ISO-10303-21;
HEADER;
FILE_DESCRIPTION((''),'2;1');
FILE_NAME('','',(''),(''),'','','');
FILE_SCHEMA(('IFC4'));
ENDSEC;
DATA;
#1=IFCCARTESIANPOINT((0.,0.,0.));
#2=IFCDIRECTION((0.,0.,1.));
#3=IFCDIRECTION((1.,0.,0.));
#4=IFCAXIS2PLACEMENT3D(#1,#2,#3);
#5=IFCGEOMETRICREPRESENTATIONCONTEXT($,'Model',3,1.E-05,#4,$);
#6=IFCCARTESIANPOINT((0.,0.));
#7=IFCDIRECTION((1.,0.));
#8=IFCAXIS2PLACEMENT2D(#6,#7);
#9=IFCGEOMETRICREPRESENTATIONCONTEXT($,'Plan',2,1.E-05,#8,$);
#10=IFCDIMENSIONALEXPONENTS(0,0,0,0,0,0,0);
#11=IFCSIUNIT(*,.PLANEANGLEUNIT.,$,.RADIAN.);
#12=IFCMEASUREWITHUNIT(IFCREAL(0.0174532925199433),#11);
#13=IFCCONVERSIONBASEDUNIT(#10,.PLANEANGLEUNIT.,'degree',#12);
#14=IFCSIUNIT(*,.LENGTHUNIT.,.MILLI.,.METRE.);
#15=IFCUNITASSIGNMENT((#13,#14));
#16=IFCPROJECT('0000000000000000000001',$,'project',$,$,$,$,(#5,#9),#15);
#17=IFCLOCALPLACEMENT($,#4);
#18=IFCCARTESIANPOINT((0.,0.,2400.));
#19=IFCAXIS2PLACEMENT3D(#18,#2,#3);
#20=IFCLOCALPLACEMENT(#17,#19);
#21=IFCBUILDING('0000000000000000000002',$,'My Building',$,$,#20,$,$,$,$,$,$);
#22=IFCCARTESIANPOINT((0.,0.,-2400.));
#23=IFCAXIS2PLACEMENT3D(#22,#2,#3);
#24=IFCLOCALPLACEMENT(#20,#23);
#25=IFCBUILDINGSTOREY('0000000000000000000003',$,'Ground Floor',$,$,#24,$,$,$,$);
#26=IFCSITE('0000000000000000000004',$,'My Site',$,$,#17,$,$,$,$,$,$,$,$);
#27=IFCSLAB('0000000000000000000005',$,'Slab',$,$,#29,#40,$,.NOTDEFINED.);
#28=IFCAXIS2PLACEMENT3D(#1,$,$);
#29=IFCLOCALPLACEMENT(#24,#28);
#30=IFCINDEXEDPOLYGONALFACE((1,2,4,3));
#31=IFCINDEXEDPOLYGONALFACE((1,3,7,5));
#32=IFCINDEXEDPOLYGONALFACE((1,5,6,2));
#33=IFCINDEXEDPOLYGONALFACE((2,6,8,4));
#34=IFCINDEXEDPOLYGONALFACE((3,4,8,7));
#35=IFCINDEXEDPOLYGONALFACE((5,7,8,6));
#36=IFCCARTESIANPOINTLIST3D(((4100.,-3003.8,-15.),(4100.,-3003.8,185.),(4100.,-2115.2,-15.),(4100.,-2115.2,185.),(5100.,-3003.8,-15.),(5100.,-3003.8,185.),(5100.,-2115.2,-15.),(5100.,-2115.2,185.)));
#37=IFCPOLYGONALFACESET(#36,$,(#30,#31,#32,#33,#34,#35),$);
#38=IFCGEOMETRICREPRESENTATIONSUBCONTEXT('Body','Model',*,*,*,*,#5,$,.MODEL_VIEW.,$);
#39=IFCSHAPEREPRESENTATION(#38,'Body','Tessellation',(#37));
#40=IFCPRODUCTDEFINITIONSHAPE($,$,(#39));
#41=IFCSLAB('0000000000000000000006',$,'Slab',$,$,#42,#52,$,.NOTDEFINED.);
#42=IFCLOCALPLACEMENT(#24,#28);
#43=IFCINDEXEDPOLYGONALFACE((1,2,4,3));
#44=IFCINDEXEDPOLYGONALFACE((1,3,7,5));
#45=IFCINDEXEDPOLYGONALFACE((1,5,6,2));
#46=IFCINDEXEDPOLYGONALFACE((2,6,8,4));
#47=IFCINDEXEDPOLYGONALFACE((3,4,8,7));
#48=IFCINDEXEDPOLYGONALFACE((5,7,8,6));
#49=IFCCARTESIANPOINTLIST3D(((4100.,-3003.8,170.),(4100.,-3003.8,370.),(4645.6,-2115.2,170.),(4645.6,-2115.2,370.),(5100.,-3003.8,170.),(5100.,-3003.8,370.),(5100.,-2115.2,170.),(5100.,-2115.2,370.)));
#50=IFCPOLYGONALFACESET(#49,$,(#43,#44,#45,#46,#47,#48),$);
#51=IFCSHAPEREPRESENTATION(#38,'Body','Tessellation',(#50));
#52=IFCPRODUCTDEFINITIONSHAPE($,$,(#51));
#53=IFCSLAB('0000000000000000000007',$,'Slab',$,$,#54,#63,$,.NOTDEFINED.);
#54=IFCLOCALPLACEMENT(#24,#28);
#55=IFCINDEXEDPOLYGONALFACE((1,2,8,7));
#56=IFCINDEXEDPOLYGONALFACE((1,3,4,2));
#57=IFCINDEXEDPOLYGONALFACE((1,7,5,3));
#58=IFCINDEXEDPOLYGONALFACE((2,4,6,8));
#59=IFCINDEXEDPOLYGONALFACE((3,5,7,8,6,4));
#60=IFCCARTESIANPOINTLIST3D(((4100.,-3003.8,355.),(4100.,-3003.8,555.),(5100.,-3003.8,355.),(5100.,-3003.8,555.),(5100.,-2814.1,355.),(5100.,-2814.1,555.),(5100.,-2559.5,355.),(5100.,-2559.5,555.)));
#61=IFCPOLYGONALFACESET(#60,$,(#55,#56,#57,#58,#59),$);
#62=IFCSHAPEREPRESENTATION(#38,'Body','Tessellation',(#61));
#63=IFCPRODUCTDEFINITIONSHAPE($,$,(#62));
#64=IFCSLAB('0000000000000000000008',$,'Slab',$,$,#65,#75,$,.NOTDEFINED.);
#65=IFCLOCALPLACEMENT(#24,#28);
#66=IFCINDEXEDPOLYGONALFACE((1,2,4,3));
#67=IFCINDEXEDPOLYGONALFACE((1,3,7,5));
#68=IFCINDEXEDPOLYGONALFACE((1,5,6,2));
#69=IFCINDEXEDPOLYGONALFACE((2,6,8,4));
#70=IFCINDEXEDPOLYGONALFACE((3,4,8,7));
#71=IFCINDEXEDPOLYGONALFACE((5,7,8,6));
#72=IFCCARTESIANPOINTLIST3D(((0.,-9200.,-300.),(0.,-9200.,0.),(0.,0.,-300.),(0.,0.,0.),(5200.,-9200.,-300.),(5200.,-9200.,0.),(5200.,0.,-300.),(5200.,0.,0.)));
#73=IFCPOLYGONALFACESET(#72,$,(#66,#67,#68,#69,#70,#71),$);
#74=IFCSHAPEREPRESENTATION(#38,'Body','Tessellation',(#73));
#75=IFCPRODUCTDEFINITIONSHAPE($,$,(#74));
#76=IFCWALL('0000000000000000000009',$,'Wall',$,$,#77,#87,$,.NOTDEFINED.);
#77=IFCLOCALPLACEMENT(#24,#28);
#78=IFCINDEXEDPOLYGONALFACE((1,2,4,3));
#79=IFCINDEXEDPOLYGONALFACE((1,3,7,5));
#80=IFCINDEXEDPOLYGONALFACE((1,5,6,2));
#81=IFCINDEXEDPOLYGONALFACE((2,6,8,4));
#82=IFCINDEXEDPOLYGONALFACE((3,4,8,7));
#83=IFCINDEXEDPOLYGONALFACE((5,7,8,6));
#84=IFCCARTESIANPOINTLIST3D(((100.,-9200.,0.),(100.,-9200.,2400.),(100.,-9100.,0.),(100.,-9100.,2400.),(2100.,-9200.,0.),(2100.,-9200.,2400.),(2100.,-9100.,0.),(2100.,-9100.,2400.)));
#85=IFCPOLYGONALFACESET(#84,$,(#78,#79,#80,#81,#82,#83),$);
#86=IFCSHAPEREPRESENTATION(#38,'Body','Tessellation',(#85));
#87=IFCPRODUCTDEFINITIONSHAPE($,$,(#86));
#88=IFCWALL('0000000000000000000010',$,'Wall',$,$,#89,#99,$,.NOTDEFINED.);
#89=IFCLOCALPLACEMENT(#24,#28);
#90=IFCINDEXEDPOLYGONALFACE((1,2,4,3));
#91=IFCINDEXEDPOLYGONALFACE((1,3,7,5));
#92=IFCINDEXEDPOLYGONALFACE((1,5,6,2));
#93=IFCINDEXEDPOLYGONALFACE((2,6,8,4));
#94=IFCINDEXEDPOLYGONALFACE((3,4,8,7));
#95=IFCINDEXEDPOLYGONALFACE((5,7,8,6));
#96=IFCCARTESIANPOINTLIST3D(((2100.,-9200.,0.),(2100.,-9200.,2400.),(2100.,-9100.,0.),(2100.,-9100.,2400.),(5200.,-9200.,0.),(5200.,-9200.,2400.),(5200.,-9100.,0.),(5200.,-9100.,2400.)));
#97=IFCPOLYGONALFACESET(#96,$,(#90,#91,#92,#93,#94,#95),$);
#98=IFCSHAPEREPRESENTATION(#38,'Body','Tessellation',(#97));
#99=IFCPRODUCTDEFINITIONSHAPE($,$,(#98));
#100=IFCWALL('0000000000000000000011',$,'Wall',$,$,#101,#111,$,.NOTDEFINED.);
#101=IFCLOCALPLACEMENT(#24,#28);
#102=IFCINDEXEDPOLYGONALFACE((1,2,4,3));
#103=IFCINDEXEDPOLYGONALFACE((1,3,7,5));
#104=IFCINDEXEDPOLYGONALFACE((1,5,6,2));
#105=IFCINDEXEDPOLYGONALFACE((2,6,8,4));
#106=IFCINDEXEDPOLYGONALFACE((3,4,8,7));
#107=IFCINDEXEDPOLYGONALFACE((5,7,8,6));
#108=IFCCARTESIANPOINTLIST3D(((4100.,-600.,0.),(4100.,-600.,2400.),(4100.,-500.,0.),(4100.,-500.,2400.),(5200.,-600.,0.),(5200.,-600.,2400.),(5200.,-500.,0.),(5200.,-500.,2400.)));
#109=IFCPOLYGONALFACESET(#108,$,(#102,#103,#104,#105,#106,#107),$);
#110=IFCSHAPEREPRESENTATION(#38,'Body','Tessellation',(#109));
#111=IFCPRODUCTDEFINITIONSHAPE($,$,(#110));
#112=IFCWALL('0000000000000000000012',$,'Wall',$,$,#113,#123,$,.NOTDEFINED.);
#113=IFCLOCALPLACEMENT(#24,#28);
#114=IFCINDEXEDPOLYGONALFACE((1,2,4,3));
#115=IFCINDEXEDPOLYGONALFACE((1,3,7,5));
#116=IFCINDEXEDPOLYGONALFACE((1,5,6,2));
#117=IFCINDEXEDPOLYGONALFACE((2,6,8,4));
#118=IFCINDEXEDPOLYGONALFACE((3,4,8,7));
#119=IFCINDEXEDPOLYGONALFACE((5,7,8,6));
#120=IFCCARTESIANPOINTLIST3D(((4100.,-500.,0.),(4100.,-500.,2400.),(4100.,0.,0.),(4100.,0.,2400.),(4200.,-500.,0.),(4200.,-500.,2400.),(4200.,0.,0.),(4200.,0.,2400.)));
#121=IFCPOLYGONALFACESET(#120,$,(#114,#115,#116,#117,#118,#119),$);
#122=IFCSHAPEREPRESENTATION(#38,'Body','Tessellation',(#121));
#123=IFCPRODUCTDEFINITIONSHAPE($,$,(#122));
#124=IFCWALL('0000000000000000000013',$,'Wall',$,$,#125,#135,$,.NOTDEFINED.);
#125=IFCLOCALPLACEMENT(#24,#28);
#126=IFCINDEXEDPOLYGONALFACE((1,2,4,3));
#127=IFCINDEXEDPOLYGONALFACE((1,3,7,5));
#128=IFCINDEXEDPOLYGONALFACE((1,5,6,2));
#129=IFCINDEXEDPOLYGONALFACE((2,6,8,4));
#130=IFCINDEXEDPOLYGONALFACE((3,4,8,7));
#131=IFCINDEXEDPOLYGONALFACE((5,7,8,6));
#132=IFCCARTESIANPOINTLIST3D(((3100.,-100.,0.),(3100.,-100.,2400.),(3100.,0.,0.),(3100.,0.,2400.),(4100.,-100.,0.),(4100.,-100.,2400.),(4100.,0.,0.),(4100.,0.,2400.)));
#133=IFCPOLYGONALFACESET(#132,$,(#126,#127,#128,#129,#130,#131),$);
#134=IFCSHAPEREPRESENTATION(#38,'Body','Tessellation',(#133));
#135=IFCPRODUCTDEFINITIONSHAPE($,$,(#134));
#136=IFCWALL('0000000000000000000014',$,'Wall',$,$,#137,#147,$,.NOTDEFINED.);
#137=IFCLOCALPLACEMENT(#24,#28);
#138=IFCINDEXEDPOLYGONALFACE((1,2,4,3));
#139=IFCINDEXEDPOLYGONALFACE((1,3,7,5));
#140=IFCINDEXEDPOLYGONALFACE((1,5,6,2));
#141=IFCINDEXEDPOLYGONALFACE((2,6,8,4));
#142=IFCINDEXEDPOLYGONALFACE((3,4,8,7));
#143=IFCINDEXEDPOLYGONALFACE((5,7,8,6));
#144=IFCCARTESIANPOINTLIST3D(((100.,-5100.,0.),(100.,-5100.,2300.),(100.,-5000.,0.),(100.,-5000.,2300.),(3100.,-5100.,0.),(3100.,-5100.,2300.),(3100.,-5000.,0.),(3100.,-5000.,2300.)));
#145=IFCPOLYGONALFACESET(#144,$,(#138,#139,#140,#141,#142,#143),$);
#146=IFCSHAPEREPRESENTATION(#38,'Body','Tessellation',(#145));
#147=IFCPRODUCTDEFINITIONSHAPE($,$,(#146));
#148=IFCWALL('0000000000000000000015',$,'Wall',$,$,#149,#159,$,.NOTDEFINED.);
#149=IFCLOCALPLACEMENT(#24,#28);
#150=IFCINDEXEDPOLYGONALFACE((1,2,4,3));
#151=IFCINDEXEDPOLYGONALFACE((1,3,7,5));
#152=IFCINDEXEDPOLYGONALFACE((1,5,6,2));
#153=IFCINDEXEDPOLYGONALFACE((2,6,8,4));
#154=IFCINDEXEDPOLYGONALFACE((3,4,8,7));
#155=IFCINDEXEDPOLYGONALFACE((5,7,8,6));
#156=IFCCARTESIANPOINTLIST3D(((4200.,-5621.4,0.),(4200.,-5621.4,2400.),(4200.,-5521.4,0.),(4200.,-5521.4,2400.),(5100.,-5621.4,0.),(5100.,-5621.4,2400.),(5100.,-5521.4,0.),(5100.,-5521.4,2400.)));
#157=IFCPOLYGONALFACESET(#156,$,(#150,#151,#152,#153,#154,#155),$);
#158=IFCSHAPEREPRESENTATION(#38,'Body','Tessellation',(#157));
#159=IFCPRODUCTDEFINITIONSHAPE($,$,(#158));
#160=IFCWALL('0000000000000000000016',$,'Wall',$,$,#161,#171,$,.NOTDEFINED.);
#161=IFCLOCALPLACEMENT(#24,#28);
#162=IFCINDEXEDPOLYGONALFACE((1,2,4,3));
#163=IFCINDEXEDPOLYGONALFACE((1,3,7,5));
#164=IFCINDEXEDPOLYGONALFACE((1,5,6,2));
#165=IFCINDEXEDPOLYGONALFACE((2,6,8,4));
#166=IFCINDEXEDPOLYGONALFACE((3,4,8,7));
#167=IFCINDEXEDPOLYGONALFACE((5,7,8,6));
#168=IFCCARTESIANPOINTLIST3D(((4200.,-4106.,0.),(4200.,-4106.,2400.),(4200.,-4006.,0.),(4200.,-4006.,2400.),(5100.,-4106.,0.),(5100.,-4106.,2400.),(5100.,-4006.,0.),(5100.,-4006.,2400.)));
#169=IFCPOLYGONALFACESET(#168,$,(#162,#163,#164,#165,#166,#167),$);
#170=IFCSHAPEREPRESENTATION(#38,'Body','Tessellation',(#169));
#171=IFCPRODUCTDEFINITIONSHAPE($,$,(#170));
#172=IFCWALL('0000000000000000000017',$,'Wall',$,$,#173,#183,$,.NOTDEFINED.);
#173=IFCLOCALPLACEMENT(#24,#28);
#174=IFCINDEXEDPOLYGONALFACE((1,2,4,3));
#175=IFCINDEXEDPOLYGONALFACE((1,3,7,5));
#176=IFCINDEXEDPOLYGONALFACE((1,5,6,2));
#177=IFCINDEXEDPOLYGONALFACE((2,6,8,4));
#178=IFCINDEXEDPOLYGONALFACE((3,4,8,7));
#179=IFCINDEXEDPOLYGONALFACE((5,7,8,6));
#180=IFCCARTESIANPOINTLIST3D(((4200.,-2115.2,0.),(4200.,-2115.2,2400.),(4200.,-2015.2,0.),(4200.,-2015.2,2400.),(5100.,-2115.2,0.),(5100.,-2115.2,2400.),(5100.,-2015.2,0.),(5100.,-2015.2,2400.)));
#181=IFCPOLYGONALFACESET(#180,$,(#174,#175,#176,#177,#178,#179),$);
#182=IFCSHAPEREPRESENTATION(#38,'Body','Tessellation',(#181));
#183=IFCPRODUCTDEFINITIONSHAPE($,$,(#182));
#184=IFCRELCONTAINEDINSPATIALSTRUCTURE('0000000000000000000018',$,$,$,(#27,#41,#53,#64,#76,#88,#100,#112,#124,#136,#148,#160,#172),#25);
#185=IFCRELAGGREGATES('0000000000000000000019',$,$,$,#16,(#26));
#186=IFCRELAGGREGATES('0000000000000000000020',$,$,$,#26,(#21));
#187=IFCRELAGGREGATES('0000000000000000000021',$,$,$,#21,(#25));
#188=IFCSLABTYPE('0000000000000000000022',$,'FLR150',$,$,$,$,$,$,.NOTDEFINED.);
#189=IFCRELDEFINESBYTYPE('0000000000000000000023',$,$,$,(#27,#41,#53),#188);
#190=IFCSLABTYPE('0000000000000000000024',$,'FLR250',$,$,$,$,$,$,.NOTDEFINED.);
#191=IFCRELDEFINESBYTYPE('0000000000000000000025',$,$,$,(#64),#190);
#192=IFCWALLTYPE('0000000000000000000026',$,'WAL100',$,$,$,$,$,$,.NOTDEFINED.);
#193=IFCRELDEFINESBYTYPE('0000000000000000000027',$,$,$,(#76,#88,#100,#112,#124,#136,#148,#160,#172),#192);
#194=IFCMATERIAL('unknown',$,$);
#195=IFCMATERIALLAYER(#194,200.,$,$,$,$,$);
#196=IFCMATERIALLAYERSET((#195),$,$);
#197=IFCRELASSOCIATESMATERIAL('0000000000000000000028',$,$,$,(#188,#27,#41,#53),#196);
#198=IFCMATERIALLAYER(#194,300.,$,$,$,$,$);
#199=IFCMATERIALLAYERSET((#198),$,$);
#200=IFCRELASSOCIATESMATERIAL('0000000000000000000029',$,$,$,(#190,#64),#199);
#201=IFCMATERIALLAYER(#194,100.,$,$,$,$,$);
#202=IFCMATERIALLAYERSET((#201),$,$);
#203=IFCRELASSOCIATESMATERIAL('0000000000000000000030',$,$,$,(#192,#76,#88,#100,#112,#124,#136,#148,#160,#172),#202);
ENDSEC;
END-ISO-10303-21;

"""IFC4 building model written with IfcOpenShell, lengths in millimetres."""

from ifc_helpers import new_model, entity, si_unit, converted_unit, frame, origin_with_axes, origin_2d_with_axis, place, context, subcontext, project, spatial, line, indexed_curve, outline, extrude, material, layer, layer_set, layer_usage, type_object, element, save


model = new_model("IFC4")

# Units and contexts
model_context = context("Model", 3, precision=1e-05, world=origin_with_axes())
plan_context = context("Plan", 2, precision=1e-05, world=origin_2d_with_axis())
body_context = subcontext(model_context, "Body", "Model", "MODEL_VIEW")
ifc_project = project(units=[converted_unit("PLANEANGLEUNIT", "degree", entity("IfcReal", 0.0174532925199433), si_unit("PLANEANGLEUNIT", "RADIAN"), dimensions=[0, 0, 0, 0, 0, 0, 0]), si_unit("LENGTHUNIT", "METRE", prefix="MILLI")], contexts=[model_context, plan_context])

# Site, building, storey
site_placement = place(None, origin_with_axes())
site = spatial("IfcSite", under=ifc_project, at=site_placement, Name="My Site")
building_placement = place(site_placement, frame((0.0, 0.0, 2400.0), z_axis=(0.0, 0.0, 1.0), x_axis=(1.0, 0.0, 0.0)))
building = spatial("IfcBuilding", under=site, at=building_placement, Name="My Building")
storey_placement = place(building_placement, frame((0.0, 0.0, -2400.0), z_axis=(0.0, 0.0, 1.0), x_axis=(1.0, 0.0, 0.0)))
storey = spatial("IfcBuildingStorey", under=building, at=storey_placement, Name="Ground Floor")

# Slabs
ifc_material = material(Name="unknown")
ifc_layer_1 = layer(ifc_material, 200.0)
ifc_layer_set_1 = layer_set([ifc_layer_1])
ifc_layer_usage_1 = layer_usage(ifc_layer_set_1, "AXIS3", "POSITIVE", 0.0)
slab_type_1 = type_object("IfcSlabType", Name="FLR150", PredefinedType="NOTDEFINED", material=ifc_layer_set_1)
slab_1_placement = place(storey_placement, frame((4100.0, -3003.8, -15.0), z_axis=(0.0, 0.0, 1.0), x_axis=(1.0, 0.0, 0.0)))
element("IfcSlab", 1, at=slab_1_placement, inside=storey, type_object=slab_type_1, material=ifc_layer_usage_1, Name="Slab", PredefinedType="NOTDEFINED", context=body_context, shape_type="SweptSolid", body=[
    extrude(outline(indexed_curve([(0.0, 0.0), (1000.0, 0.0), (1000.0, 888.7), (0.0, 888.7)], segments=[line(4, 1), line(1, 2), line(2, 3), line(3, 4)], self_intersect=False)), None, (0.0, 0.0, 1.0), 200.0),
])
ifc_layer_usage_2 = layer_usage(ifc_layer_set_1, "AXIS3", "POSITIVE", 0.0)
slab_2_placement = place(storey_placement, frame((4100.0, -3003.8, 170.0), z_axis=(0.0, 0.0, 1.0), x_axis=(1.0, 0.0, 0.0)))
element("IfcSlab", 2, at=slab_2_placement, inside=storey, type_object=slab_type_1, material=ifc_layer_usage_2, Name="Slab", PredefinedType="NOTDEFINED", context=body_context, shape_type="SweptSolid", body=[
    extrude(outline(indexed_curve([(0.0, 0.0), (1000.0, 0.0), (1000.0, 888.7), (545.6, 888.7)], segments=[line(4, 1), line(1, 2), line(2, 3), line(3, 4)], self_intersect=False)), None, (0.0, 0.0, 1.0), 200.0),
])
ifc_layer_usage_3 = layer_usage(ifc_layer_set_1, "AXIS3", "POSITIVE", 0.0)
slab_3_placement = place(storey_placement, frame((4100.0, -3003.8, 355.0), z_axis=(0.0, 0.0, 1.0), x_axis=(1.0, 0.0, 0.0)))
element("IfcSlab", 3, at=slab_3_placement, inside=storey, type_object=slab_type_1, material=ifc_layer_usage_3, Name="Slab", PredefinedType="NOTDEFINED", context=body_context, shape_type="SweptSolid", body=[
    extrude(outline(indexed_curve([(0.0, 0.0), (1000.0, 0.0), (1000.0, 189.7), (1000.0, 444.3)], segments=[line(4, 1), line(1, 2), line(2, 3), line(3, 4)], self_intersect=False)), None, (0.0, 0.0, 1.0), 200.0),
])
ifc_layer_2 = layer(ifc_material, 300.0)
ifc_layer_set_2 = layer_set([ifc_layer_2])
ifc_layer_usage_4 = layer_usage(ifc_layer_set_2, "AXIS3", "POSITIVE", 0.0)
slab_type_2 = type_object("IfcSlabType", Name="FLR250", PredefinedType="NOTDEFINED", material=ifc_layer_set_2)
slab_4_placement = place(storey_placement, frame((0.0, -9200.0, -300.0), z_axis=(0.0, 0.0, 1.0), x_axis=(1.0, 0.0, 0.0)))
element("IfcSlab", 4, at=slab_4_placement, inside=storey, type_object=slab_type_2, material=ifc_layer_usage_4, Name="Slab", PredefinedType="NOTDEFINED", context=body_context, shape_type="SweptSolid", body=[
    extrude(outline(indexed_curve([(0.0, 0.0), (5200.0, 0.0), (5200.0, 9200.0), (0.0, 9200.0)], segments=[line(3, 2), line(2, 1), line(1, 4), line(4, 3)], self_intersect=False)), None, (0.0, 0.0, 1.0), 300.0),
])

# Walls
ifc_layer_3 = layer(ifc_material, 100.0)
ifc_layer_set_3 = layer_set([ifc_layer_3])
ifc_layer_usage_5 = layer_usage(ifc_layer_set_3, "AXIS2", "POSITIVE", 0.0)
wall_type = type_object("IfcWallType", Name="WAL100", PredefinedType="NOTDEFINED", material=ifc_layer_set_3)
wall_1_placement = place(storey_placement, frame((100.0, -9200.0, 0.0), z_axis=(0.0, 0.0, 1.0), x_axis=(1.0, -0.000002, 0.0)))
element("IfcWall", 5, at=wall_1_placement, inside=storey, type_object=wall_type, material=ifc_layer_usage_5, Name="Wall", PredefinedType="NOTDEFINED", context=body_context, shape_type="SweptSolid", body=[
    extrude(outline(indexed_curve([(0.0, 0.0), (0.0, 100.0), (2000.0, 100.0), (2000.0, 0.0), (0.0, 0.0)], self_intersect=False)), origin_with_axes(), (0.0, 0.0, 1.0), 2400.0),
])
ifc_layer_usage_6 = layer_usage(ifc_layer_set_3, "AXIS2", "POSITIVE", 0.0)
wall_2_placement = place(storey_placement, frame((2100.0, -9200.0, 0.0), z_axis=(0.0, 0.0, 1.0), x_axis=(1.0, -0.000002, 0.0)))
element("IfcWall", 6, at=wall_2_placement, inside=storey, type_object=wall_type, material=ifc_layer_usage_6, Name="Wall", PredefinedType="NOTDEFINED", context=body_context, shape_type="SweptSolid", body=[
    extrude(outline(indexed_curve([(0.0, 0.0), (0.0, 100.0), (3100.0, 100.0), (3100.0, 0.0), (0.0, 0.0)], self_intersect=False)), origin_with_axes(), (0.0, 0.0, 1.0), 2400.0),
])
ifc_layer_usage_7 = layer_usage(ifc_layer_set_3, "AXIS2", "POSITIVE", 0.0)
wall_3_placement = place(storey_placement, frame((5200.0, -500.0, 0.0), z_axis=(0.0, 0.0, 1.0), x_axis=(-1.0, 0.000002, 0.0)))
element("IfcWall", 7, at=wall_3_placement, inside=storey, type_object=wall_type, material=ifc_layer_usage_7, Name="Wall", PredefinedType="NOTDEFINED", context=body_context, shape_type="SweptSolid", body=[
    extrude(outline(indexed_curve([(0.0, 0.0), (0.0, 100.0), (1100.0, 100.0), (1100.0, 0.0), (0.0, 0.0)], self_intersect=False)), origin_with_axes(), (0.0, 0.0, 1.0), 2400.0),
])
ifc_layer_usage_8 = layer_usage(ifc_layer_set_3, "AXIS2", "POSITIVE", 0.0)
wall_4_placement = place(storey_placement, frame((4100.0, 0.0, 0.0), z_axis=(0.0, 0.0, 1.0), x_axis=(-0.000003, -1.0, 0.0)))
element("IfcWall", 8, at=wall_4_placement, inside=storey, type_object=wall_type, material=ifc_layer_usage_8, Name="Wall", PredefinedType="NOTDEFINED", context=body_context, shape_type="SweptSolid", body=[
    extrude(outline(indexed_curve([(0.0, 0.0), (0.0, 100.0), (500.0, 100.0), (500.0, 0.0), (0.0, 0.0)], self_intersect=False)), origin_with_axes(), (0.0, 0.0, 1.0), 2400.0),
])
ifc_layer_usage_9 = layer_usage(ifc_layer_set_3, "AXIS2", "POSITIVE", 0.0)
wall_5_placement = place(storey_placement, frame((4100.0, 0.0, 0.0), z_axis=(0.0, 0.0, 1.0), x_axis=(-1.0, 0.000003, 0.0)))
element("IfcWall", 9, at=wall_5_placement, inside=storey, type_object=wall_type, material=ifc_layer_usage_9, Name="Wall", PredefinedType="NOTDEFINED", context=body_context, shape_type="SweptSolid", body=[
    extrude(outline(indexed_curve([(0.0, 0.0), (0.0, 100.0), (1000.0, 100.0), (1000.0, 0.0), (0.0, 0.0)], self_intersect=False)), origin_with_axes(), (0.0, 0.0, 1.0), 2400.0),
])
ifc_layer_usage_10 = layer_usage(ifc_layer_set_3, "AXIS2", "POSITIVE", 0.0)
wall_6_placement = place(storey_placement, frame((3100.0, -5000.0, 0.0), z_axis=(0.0, 0.0, 1.0), x_axis=(-1.0, 0.000004, 0.0)))
element("IfcWall", 10, at=wall_6_placement, inside=storey, type_object=wall_type, material=ifc_layer_usage_10, Name="Wall", PredefinedType="NOTDEFINED", context=body_context, shape_type="SweptSolid", body=[
    extrude(outline(indexed_curve([(0.0, 0.0), (0.0, 100.0), (3000.0, 100.0), (3000.0, 0.0), (0.0, 0.0)], self_intersect=False)), origin_with_axes(), (0.0, 0.0, 1.0), 2300.0),
])
ifc_layer_usage_11 = layer_usage(ifc_layer_set_3, "AXIS2", "POSITIVE", 0.0)
wall_7_placement = place(storey_placement, frame((4200.0, -5621.4, 0.0), z_axis=(0.0, 0.0, 1.0), x_axis=(1.0, -0.000002, 0.0)))
element("IfcWall", 11, at=wall_7_placement, inside=storey, type_object=wall_type, material=ifc_layer_usage_11, Name="Wall", PredefinedType="NOTDEFINED", context=body_context, shape_type="SweptSolid", body=[
    extrude(outline(indexed_curve([(0.0, 0.0), (0.0, 100.0), (900.0, 100.0), (900.0, 0.0), (0.0, 0.0)], self_intersect=False)), origin_with_axes(), (0.0, 0.0, 1.0), 2400.0),
])
ifc_layer_usage_12 = layer_usage(ifc_layer_set_3, "AXIS2", "POSITIVE", 0.0)
wall_8_placement = place(storey_placement, frame((4200.0, -4106.0, 0.0), z_axis=(0.0, 0.0, 1.0), x_axis=(1.0, -0.000002, 0.0)))
element("IfcWall", 12, at=wall_8_placement, inside=storey, type_object=wall_type, material=ifc_layer_usage_12, Name="Wall", PredefinedType="NOTDEFINED", context=body_context, shape_type="SweptSolid", body=[
    extrude(outline(indexed_curve([(0.0, 0.0), (0.0, 100.0), (900.0, 100.0), (900.0, 0.0), (0.0, 0.0)], self_intersect=False)), origin_with_axes(), (0.0, 0.0, 1.0), 2400.0),
])
ifc_layer_usage_13 = layer_usage(ifc_layer_set_3, "AXIS2", "POSITIVE", 0.0)
wall_9_placement = place(storey_placement, frame((4200.0, -2115.2, 0.0), z_axis=(0.0, 0.0, 1.0), x_axis=(1.0, -0.000002, 0.0)))
element("IfcWall", 13, at=wall_9_placement, inside=storey, type_object=wall_type, material=ifc_layer_usage_13, Name="Wall", PredefinedType="NOTDEFINED", context=body_context, shape_type="SweptSolid", body=[
    extrude(outline(indexed_curve([(0.0, 0.0), (0.0, 100.0), (900.0, 100.0), (900.0, 0.0), (0.0, 0.0)], self_intersect=False)), origin_with_axes(), (0.0, 0.0, 1.0), 2400.0),
])

save(model, "model.ifc")
